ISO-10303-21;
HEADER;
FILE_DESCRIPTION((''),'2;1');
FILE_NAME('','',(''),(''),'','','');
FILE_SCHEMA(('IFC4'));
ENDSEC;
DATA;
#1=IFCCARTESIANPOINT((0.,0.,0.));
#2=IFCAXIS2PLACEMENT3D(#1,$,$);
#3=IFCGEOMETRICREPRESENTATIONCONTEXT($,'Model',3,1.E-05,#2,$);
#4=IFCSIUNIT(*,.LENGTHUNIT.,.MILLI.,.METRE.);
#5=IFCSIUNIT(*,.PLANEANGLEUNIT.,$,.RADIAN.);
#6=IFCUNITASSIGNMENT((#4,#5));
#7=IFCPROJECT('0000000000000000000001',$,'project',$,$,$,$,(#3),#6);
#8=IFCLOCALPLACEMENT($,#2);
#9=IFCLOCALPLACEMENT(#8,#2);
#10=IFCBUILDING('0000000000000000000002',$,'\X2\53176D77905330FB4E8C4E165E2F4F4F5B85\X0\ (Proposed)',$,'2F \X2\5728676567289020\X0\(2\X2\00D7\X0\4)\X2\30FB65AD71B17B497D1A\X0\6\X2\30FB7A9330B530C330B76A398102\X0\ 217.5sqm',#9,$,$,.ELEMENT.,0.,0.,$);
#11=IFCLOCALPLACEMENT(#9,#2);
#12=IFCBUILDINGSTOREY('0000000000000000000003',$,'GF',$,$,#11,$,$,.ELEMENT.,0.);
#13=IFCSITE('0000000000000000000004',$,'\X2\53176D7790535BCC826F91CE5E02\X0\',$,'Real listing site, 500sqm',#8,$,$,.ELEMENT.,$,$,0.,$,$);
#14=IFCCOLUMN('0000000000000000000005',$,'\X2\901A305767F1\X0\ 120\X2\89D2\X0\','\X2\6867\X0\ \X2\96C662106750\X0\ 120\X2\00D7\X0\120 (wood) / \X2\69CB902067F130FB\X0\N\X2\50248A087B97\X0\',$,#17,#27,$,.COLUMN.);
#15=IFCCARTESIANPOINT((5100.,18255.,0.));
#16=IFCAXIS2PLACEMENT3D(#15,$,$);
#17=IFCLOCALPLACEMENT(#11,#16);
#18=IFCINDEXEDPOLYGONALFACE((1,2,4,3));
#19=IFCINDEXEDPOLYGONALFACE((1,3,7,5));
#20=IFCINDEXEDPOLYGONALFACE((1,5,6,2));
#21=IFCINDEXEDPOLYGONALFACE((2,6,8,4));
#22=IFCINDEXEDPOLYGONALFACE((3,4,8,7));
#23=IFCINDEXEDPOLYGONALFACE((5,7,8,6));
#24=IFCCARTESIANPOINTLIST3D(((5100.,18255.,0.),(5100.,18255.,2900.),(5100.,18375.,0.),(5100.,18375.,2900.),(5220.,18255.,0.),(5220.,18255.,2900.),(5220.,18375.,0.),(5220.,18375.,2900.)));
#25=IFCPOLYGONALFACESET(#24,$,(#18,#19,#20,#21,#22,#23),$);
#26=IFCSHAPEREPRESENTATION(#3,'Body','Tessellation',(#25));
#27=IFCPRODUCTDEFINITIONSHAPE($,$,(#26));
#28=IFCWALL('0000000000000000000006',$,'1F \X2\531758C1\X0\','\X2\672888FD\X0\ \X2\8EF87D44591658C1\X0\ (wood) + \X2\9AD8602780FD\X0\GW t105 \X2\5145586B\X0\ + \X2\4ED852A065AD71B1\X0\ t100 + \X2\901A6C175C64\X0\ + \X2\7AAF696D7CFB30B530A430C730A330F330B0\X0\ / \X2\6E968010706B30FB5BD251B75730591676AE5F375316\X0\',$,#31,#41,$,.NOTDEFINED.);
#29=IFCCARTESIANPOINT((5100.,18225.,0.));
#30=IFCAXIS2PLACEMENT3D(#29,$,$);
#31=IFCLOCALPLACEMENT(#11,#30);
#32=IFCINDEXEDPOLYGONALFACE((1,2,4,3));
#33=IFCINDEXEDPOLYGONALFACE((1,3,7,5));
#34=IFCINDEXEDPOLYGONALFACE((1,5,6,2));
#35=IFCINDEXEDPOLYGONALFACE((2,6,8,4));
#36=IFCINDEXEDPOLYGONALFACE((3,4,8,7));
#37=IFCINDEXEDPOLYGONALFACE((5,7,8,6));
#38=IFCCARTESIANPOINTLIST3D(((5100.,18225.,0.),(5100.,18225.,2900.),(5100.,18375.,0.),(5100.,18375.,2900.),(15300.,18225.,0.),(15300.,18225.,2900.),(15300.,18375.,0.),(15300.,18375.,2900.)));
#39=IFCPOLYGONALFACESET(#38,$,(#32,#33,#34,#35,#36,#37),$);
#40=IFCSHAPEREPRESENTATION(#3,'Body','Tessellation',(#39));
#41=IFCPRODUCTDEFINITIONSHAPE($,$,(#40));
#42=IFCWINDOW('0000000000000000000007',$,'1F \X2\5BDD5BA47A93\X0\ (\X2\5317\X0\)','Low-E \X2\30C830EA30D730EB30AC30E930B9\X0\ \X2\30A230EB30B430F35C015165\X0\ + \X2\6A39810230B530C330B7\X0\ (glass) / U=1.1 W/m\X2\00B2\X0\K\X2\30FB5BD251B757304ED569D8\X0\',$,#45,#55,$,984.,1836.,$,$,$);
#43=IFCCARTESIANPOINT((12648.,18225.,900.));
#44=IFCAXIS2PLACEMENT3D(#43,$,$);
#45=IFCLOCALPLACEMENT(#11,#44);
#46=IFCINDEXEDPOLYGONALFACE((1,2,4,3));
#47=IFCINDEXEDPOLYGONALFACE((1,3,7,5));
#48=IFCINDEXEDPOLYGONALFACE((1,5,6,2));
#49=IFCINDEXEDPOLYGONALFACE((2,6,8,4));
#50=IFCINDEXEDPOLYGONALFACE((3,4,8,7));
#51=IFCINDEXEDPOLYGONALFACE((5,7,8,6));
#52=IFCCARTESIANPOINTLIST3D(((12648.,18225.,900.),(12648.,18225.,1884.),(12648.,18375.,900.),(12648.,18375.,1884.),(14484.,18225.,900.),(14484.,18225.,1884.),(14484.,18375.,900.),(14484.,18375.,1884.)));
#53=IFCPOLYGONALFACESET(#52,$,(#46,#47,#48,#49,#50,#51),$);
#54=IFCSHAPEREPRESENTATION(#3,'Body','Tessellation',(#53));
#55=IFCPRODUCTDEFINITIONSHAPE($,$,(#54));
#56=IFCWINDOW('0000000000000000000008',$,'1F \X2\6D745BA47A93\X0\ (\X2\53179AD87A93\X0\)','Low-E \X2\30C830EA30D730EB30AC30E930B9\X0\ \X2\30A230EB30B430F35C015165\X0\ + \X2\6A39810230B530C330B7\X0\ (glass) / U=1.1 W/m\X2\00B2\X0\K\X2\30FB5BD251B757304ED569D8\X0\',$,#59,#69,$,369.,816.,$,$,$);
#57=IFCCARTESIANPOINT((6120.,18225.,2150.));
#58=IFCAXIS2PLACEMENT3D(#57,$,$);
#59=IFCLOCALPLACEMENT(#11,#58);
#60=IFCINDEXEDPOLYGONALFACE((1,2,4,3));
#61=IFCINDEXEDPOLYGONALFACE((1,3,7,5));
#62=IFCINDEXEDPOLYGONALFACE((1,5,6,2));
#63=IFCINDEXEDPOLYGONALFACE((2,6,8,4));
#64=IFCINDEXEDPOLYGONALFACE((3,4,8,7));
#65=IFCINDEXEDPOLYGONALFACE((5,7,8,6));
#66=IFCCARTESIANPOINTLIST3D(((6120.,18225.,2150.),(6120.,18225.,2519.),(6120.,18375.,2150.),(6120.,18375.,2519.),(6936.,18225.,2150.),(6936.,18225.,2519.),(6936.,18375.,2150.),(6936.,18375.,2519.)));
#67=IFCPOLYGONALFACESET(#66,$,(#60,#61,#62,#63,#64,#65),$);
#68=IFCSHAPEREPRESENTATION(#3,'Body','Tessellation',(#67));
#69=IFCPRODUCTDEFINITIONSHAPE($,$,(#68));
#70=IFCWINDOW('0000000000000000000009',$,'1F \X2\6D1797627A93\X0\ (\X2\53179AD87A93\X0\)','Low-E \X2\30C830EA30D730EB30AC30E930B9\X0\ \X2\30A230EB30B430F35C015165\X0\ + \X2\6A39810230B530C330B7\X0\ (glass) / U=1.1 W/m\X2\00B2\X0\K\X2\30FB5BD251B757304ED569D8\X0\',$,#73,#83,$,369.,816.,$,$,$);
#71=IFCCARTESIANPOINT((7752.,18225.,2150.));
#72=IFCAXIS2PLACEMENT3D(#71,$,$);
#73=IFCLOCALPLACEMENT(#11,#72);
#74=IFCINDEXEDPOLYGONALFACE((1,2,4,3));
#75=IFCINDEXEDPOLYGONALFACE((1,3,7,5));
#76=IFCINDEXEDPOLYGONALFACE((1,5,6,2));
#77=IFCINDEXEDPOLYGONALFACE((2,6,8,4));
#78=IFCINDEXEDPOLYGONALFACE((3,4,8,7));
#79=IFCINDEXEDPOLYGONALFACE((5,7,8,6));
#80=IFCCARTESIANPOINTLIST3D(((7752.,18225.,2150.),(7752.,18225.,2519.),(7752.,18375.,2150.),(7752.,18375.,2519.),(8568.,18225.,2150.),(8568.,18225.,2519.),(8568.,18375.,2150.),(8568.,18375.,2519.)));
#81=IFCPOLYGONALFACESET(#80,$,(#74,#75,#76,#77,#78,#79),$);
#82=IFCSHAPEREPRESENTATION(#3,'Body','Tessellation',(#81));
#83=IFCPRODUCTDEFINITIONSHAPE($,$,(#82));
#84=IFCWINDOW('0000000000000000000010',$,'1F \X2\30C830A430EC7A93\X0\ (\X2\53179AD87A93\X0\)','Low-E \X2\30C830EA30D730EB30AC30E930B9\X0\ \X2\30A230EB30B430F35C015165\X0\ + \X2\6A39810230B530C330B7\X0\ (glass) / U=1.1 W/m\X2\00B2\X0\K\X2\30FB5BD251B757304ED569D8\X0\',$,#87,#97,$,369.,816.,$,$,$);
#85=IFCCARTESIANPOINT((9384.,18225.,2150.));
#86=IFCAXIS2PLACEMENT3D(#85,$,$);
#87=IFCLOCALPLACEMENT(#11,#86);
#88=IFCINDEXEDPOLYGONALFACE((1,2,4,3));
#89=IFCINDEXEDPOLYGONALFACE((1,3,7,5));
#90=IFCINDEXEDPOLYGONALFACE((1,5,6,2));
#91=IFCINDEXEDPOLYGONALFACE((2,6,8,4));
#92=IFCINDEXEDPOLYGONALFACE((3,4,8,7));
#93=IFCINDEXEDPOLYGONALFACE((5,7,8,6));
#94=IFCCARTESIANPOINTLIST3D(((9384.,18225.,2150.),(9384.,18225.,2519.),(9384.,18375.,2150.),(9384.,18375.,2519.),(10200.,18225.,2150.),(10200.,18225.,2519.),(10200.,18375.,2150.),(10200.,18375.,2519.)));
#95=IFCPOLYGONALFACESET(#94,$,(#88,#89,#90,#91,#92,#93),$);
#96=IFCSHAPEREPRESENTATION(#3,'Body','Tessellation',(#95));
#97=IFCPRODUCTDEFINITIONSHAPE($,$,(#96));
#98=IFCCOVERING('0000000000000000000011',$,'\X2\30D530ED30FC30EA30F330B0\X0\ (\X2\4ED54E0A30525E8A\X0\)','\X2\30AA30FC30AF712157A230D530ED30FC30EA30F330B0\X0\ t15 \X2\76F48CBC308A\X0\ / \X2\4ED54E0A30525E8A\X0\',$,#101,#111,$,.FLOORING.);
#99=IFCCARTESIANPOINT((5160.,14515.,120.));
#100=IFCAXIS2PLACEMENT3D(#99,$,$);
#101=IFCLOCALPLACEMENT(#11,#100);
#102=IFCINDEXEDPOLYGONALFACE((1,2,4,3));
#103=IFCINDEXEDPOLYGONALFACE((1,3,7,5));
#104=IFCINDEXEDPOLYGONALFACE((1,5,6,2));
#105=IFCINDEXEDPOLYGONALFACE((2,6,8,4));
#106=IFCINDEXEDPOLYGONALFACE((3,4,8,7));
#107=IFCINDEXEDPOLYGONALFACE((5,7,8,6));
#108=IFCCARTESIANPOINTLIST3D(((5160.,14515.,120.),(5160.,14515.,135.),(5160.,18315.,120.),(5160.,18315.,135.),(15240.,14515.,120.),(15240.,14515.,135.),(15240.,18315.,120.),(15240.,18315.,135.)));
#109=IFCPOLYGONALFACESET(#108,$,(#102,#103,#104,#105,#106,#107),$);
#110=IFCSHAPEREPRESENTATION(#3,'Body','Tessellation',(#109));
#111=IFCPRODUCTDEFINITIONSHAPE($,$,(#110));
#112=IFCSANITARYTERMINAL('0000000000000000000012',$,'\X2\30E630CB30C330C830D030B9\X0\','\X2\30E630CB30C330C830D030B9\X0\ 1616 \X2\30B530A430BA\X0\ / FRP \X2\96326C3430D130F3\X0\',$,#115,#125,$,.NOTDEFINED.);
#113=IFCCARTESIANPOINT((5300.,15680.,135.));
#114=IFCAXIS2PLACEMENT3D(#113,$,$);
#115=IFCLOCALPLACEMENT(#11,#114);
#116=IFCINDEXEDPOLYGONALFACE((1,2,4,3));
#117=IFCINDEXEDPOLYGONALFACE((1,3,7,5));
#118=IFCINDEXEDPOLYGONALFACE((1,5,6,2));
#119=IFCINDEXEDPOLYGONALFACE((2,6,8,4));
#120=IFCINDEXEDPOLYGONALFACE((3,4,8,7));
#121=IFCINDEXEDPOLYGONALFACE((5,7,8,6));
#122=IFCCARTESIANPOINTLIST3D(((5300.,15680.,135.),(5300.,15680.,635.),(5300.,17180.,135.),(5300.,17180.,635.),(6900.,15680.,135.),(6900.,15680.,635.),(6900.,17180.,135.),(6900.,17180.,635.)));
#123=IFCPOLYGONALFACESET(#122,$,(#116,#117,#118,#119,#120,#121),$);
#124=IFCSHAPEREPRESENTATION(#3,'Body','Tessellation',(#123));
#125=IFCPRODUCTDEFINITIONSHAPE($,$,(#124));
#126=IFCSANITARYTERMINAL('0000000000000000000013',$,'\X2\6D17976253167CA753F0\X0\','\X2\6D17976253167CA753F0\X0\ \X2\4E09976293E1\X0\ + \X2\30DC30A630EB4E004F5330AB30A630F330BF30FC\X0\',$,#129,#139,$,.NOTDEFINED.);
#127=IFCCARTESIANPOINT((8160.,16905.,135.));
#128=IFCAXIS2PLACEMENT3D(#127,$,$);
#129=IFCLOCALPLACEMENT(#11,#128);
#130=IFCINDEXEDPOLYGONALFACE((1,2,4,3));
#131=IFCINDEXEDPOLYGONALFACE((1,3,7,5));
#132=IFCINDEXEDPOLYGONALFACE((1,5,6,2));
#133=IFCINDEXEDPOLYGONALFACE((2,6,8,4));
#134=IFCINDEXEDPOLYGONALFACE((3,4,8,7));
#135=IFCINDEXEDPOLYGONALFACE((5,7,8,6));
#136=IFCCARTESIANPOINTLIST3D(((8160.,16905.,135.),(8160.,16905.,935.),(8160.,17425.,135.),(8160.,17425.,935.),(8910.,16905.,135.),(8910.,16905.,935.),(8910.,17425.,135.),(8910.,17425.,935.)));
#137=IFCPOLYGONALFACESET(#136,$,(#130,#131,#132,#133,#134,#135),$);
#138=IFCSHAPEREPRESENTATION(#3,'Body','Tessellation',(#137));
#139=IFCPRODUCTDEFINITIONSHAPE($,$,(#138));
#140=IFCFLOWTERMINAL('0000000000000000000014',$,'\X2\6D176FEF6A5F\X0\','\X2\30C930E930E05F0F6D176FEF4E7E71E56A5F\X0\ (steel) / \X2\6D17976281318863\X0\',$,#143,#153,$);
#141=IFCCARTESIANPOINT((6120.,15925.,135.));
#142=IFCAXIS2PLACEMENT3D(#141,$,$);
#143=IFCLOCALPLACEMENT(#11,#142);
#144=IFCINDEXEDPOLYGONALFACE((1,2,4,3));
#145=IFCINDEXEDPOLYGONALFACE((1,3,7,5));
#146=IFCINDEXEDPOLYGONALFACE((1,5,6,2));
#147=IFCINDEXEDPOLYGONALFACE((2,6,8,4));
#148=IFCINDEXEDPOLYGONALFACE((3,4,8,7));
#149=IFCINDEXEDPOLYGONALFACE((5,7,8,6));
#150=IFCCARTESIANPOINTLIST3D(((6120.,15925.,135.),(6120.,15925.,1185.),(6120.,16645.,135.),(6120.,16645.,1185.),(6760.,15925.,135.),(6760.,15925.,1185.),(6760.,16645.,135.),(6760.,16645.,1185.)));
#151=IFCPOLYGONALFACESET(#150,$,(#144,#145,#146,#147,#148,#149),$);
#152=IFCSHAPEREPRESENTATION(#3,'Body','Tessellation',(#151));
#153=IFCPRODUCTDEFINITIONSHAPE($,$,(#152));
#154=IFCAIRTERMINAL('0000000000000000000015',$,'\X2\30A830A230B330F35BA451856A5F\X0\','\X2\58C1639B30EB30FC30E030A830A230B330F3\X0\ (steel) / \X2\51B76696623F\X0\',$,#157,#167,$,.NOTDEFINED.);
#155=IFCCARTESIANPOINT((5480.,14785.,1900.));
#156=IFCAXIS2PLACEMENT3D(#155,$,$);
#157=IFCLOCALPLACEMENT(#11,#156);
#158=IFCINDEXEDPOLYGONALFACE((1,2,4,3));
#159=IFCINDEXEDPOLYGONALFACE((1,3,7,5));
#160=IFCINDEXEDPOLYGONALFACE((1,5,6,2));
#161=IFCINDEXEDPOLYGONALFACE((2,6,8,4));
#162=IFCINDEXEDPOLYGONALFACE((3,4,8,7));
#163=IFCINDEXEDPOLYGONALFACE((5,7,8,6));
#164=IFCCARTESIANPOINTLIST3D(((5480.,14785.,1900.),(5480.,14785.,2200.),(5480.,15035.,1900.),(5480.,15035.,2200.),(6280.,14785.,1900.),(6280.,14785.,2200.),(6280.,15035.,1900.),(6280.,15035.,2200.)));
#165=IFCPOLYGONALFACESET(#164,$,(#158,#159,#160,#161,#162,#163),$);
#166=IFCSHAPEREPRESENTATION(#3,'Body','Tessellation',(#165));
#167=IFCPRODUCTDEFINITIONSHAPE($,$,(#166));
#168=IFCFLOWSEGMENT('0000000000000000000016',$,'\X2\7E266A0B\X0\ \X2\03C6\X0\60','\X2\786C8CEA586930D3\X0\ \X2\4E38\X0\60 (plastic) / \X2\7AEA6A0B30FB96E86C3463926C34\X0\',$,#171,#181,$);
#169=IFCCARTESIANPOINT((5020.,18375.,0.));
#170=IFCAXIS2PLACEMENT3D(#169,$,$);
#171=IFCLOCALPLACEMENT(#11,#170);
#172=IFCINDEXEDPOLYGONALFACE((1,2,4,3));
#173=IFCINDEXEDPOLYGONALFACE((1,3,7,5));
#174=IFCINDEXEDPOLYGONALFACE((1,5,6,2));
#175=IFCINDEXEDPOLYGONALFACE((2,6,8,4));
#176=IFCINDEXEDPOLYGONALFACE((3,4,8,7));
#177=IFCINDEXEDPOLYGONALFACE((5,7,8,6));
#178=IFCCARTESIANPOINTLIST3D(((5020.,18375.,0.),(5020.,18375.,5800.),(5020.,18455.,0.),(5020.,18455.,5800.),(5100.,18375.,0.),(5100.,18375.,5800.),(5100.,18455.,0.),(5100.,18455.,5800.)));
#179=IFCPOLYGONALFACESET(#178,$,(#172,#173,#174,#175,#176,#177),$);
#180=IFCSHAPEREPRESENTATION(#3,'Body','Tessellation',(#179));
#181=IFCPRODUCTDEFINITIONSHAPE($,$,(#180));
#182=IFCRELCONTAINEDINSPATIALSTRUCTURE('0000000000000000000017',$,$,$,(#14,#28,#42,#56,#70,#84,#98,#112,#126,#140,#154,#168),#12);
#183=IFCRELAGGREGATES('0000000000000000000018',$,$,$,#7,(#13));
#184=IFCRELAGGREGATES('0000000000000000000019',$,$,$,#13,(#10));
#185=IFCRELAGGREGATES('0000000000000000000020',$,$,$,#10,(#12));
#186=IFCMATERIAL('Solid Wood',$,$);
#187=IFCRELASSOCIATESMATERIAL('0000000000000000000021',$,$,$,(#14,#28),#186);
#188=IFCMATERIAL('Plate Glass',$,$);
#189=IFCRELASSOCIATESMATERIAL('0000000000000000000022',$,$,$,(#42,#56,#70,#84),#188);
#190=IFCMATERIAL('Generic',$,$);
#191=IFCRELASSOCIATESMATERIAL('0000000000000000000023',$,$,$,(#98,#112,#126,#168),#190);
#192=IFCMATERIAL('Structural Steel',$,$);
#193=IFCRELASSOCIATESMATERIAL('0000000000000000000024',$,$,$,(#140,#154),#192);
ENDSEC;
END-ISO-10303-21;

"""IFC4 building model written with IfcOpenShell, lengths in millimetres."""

from ifc_helpers import new_model, si_unit, frame, frame_2d, origin, place, context, project, spatial, rectangle, extrude, material, element, fill, save


model = new_model("IFC4")

# Units and contexts
model_context = context("Model", 3, precision=1e-05, world=origin())
ifc_project = project(units=[si_unit("LENGTHUNIT", "METRE", prefix="MILLI"), si_unit("PLANEANGLEUNIT", "RADIAN")], contexts=[model_context])

# Site, building, storey
site_placement = place(None, origin())
site = spatial("IfcSite", under=ifc_project, at=site_placement, Name="北海道富良野市", ObjectType="Real listing site, 500sqm", CompositionType="ELEMENT", RefElevation=0.0)
building_placement = place(site_placement, origin())
building = spatial("IfcBuilding", under=site, at=building_placement, Name="北海道・二世帯住宅 (Proposed)", ObjectType="2F 在来木造(2×4)・断熱等級6・窓サッシ樹脂 217.5sqm", CompositionType="ELEMENT", ElevationOfRefHeight=0.0, ElevationOfTerrain=0.0)
storey_placement = place(building_placement, origin())
storey = spatial("IfcBuildingStorey", under=building, at=storey_placement, Name="GF", CompositionType="ELEMENT", Elevation=0.0)

# Column
ifc_material_1 = material(Name="Solid Wood")
column_1_placement = place(storey_placement, frame((5100.0, 18255.0, 0.0)))
element("IfcColumn", 1, at=column_1_placement, inside=storey, material=ifc_material_1, Name="通し柱 120角", Description="桧 集成材 120×120 (wood) / 構造柱・N値計算", PredefinedType="COLUMN", context=model_context, shape_type="SweptSolid", body=[
    extrude(rectangle(XDim=120.0, YDim=120.0, at=frame_2d((60.0, 60.0))), frame((5100.0, 18255.0, 0.0)), (0.0, 0.0, 1.0), 2900.0),
])

# Wall, openings, windows
wall_1_placement = place(storey_placement, frame((5100.0, 18225.0, 0.0)))
wall_1 = element("IfcWall", 2, at=wall_1_placement, inside=storey, material=ifc_material_1, Name="1F 北壁", Description="木製 軸組外壁 (wood) + 高性能GW t105 充填 + 付加断熱 t100 + 通気層 + 窯業系サイディング / 準耐火・寒冷地外皮強化", PredefinedType="NOTDEFINED", context=model_context, shape_type="SweptSolid", body=[
    extrude(rectangle(XDim=10200.0, YDim=150.0, at=frame_2d((5100.0, 75.0))), frame((5100.0, 18225.0, 0.0)), (0.0, 0.0, 1.0), 2900.0),
])
opening_1_placement = place(storey_placement, frame((12648.0, 18225.0, 900.0)))
opening_1 = element("IfcOpeningElement", 3, at=opening_1_placement, cuts=wall_1, PredefinedType="NOTDEFINED", context=model_context, shape_type="SweptSolid", body=[
    extrude(rectangle(XDim=1836.0, YDim=150.0, at=frame_2d((918.0, 75.0))), frame((12648.0, 18225.0, 900.0)), (0.0, 0.0, 1.0), 984.0),
])
opening_2_placement = place(storey_placement, frame((6120.0, 18225.0, 2150.0)))
opening_2 = element("IfcOpeningElement", 4, at=opening_2_placement, cuts=wall_1, PredefinedType="NOTDEFINED", context=model_context, shape_type="SweptSolid", body=[
    extrude(rectangle(XDim=816.0, YDim=150.0, at=frame_2d((408.0, 75.0))), frame((6120.0, 18225.0, 2150.0)), (0.0, 0.0, 1.0), 369.0),
])
opening_3_placement = place(storey_placement, frame((7752.0, 18225.0, 2150.0)))
opening_3 = element("IfcOpeningElement", 5, at=opening_3_placement, cuts=wall_1, PredefinedType="NOTDEFINED", context=model_context, shape_type="SweptSolid", body=[
    extrude(rectangle(XDim=816.0, YDim=150.0, at=frame_2d((408.0, 75.0))), frame((7752.0, 18225.0, 2150.0)), (0.0, 0.0, 1.0), 369.0),
])
opening_4_placement = place(storey_placement, frame((9384.0, 18225.0, 2150.0)))
opening_4 = element("IfcOpeningElement", 6, at=opening_4_placement, cuts=wall_1, PredefinedType="NOTDEFINED", context=model_context, shape_type="SweptSolid", body=[
    extrude(rectangle(XDim=816.0, YDim=150.0, at=frame_2d((408.0, 75.0))), frame((9384.0, 18225.0, 2150.0)), (0.0, 0.0, 1.0), 369.0),
])
ifc_material_2 = material(Name="Plate Glass")
window_1_placement = place(storey_placement, frame((12648.0, 18225.0, 900.0)))
window_1 = element("IfcWindow", 7, at=window_1_placement, inside=storey, material=ifc_material_2, Name="1F 寝室窓 (北)", Description="Low-E トリプルガラス アルゴン封入 + 樹脂サッシ (glass) / U=1.1 W/m²K・寒冷地仕様", OverallHeight=984.0, OverallWidth=1836.0, context=model_context, shape_type="SweptSolid", body=[
    extrude(rectangle(XDim=1836.0, YDim=150.0, at=frame_2d((918.0, 75.0))), frame((12648.0, 18225.0, 900.0)), (0.0, 0.0, 1.0), 984.0),
])
fill(opening_1, window_1)
window_2_placement = place(storey_placement, frame((6120.0, 18225.0, 2150.0)))
window_2 = element("IfcWindow", 8, at=window_2_placement, inside=storey, material=ifc_material_2, Name="1F 浴室窓 (北高窓)", Description="Low-E トリプルガラス アルゴン封入 + 樹脂サッシ (glass) / U=1.1 W/m²K・寒冷地仕様", OverallHeight=369.0, OverallWidth=816.0, context=model_context, shape_type="SweptSolid", body=[
    extrude(rectangle(XDim=816.0, YDim=150.0, at=frame_2d((408.0, 75.0))), frame((6120.0, 18225.0, 2150.0)), (0.0, 0.0, 1.0), 369.0),
])
fill(opening_2, window_2)
window_3_placement = place(storey_placement, frame((7752.0, 18225.0, 2150.0)))
window_3 = element("IfcWindow", 9, at=window_3_placement, inside=storey, material=ifc_material_2, Name="1F 洗面窓 (北高窓)", Description="Low-E トリプルガラス アルゴン封入 + 樹脂サッシ (glass) / U=1.1 W/m²K・寒冷地仕様", OverallHeight=369.0, OverallWidth=816.0, context=model_context, shape_type="SweptSolid", body=[
    extrude(rectangle(XDim=816.0, YDim=150.0, at=frame_2d((408.0, 75.0))), frame((7752.0, 18225.0, 2150.0)), (0.0, 0.0, 1.0), 369.0),
])
fill(opening_3, window_3)
window_4_placement = place(storey_placement, frame((9384.0, 18225.0, 2150.0)))
window_4 = element("IfcWindow", 10, at=window_4_placement, inside=storey, material=ifc_material_2, Name="1F トイレ窓 (北高窓)", Description="Low-E トリプルガラス アルゴン封入 + 樹脂サッシ (glass) / U=1.1 W/m²K・寒冷地仕様", OverallHeight=369.0, OverallWidth=816.0, context=model_context, shape_type="SweptSolid", body=[
    extrude(rectangle(XDim=816.0, YDim=150.0, at=frame_2d((408.0, 75.0))), frame((9384.0, 18225.0, 2150.0)), (0.0, 0.0, 1.0), 369.0),
])
fill(opening_4, window_4)

# Covering
ifc_material_3 = material(Name="Generic")
covering_placement = place(storey_placement, frame((5160.0, 14515.0, 120.0)))
element("IfcCovering", 11, at=covering_placement, inside=storey, material=ifc_material_3, Name="フローリング (仕上げ床)", Description="オーク無垢フローリング t15 直貼り / 仕上げ床", PredefinedType="FLOORING", context=model_context, shape_type="SweptSolid", body=[
    extrude(rectangle(XDim=10080.0, YDim=3800.0, at=frame_2d((5040.0, 1900.0))), frame((5160.0, 14515.0, 120.0)), (0.0, 0.0, 1.0), 15.0),
])

# Sanitary terminals
sanitary_terminal_1_placement = place(storey_placement, frame((5300.0, 15680.0, 135.0)))
element("IfcSanitaryTerminal", 12, at=sanitary_terminal_1_placement, inside=storey, material=ifc_material_3, Name="ユニットバス", Description="ユニットバス 1616 サイズ / FRP 防水パン", PredefinedType="NOTDEFINED", context=model_context, shape_type="SweptSolid", body=[
    extrude(rectangle(XDim=1600.0, YDim=1500.0, at=frame_2d((800.0, 750.0))), frame((5300.0, 15680.0, 135.0)), (0.0, 0.0, 1.0), 500.0),
])
sanitary_terminal_2_placement = place(storey_placement, frame((8160.0, 16905.0, 135.0)))
element("IfcSanitaryTerminal", 13, at=sanitary_terminal_2_placement, inside=storey, material=ifc_material_3, Name="洗面化粧台", Description="洗面化粧台 三面鏡 + ボウル一体カウンター", PredefinedType="NOTDEFINED", context=model_context, shape_type="SweptSolid", body=[
    extrude(rectangle(XDim=750.0, YDim=520.0, at=frame_2d((375.0, 260.0))), frame((8160.0, 16905.0, 135.0)), (0.0, 0.0, 1.0), 800.0),
])

# Flow terminal
ifc_material_4 = material(Name="Structural Steel")
flow_terminal_placement = place(storey_placement, frame((6120.0, 15925.0, 135.0)))
element("IfcFlowTerminal", 14, at=flow_terminal_placement, inside=storey, material=ifc_material_4, Name="洗濯機", Description="ドラム式洗濯乾燥機 (steel) / 洗面脱衣", context=model_context, shape_type="SweptSolid", body=[
    extrude(rectangle(XDim=640.0, YDim=720.0, at=frame_2d((320.0, 360.0))), frame((6120.0, 15925.0, 135.0)), (0.0, 0.0, 1.0), 1050.0),
])

# Air terminal
air_terminal_placement = place(storey_placement, frame((5480.0, 14785.0, 1900.0)))
element("IfcAirTerminal", 15, at=air_terminal_placement, inside=storey, material=ifc_material_4, Name="エアコン室内機", Description="壁掛ルームエアコン (steel) / 冷暖房", PredefinedType="NOTDEFINED", context=model_context, shape_type="SweptSolid", body=[
    extrude(rectangle(XDim=800.0, YDim=250.0, at=frame_2d((400.0, 125.0))), frame((5480.0, 14785.0, 1900.0)), (0.0, 0.0, 1.0), 300.0),
])

# Flow segment
flow_segment_placement = place(storey_placement, frame((5020.0, 18375.0, 0.0)))
element("IfcFlowSegment", 16, at=flow_segment_placement, inside=storey, material=ifc_material_3, Name="縦樋 φ60", Description="硬質塩ビ 丸60 (plastic) / 竪樋・雨水排水", context=model_context, shape_type="SweptSolid", body=[
    extrude(rectangle(XDim=80.0, YDim=80.0, at=frame_2d((40.0, 40.0))), frame((5020.0, 18375.0, 0.0)), (0.0, 0.0, 1.0), 5800.0),
])

save(model, "model.ifc")
